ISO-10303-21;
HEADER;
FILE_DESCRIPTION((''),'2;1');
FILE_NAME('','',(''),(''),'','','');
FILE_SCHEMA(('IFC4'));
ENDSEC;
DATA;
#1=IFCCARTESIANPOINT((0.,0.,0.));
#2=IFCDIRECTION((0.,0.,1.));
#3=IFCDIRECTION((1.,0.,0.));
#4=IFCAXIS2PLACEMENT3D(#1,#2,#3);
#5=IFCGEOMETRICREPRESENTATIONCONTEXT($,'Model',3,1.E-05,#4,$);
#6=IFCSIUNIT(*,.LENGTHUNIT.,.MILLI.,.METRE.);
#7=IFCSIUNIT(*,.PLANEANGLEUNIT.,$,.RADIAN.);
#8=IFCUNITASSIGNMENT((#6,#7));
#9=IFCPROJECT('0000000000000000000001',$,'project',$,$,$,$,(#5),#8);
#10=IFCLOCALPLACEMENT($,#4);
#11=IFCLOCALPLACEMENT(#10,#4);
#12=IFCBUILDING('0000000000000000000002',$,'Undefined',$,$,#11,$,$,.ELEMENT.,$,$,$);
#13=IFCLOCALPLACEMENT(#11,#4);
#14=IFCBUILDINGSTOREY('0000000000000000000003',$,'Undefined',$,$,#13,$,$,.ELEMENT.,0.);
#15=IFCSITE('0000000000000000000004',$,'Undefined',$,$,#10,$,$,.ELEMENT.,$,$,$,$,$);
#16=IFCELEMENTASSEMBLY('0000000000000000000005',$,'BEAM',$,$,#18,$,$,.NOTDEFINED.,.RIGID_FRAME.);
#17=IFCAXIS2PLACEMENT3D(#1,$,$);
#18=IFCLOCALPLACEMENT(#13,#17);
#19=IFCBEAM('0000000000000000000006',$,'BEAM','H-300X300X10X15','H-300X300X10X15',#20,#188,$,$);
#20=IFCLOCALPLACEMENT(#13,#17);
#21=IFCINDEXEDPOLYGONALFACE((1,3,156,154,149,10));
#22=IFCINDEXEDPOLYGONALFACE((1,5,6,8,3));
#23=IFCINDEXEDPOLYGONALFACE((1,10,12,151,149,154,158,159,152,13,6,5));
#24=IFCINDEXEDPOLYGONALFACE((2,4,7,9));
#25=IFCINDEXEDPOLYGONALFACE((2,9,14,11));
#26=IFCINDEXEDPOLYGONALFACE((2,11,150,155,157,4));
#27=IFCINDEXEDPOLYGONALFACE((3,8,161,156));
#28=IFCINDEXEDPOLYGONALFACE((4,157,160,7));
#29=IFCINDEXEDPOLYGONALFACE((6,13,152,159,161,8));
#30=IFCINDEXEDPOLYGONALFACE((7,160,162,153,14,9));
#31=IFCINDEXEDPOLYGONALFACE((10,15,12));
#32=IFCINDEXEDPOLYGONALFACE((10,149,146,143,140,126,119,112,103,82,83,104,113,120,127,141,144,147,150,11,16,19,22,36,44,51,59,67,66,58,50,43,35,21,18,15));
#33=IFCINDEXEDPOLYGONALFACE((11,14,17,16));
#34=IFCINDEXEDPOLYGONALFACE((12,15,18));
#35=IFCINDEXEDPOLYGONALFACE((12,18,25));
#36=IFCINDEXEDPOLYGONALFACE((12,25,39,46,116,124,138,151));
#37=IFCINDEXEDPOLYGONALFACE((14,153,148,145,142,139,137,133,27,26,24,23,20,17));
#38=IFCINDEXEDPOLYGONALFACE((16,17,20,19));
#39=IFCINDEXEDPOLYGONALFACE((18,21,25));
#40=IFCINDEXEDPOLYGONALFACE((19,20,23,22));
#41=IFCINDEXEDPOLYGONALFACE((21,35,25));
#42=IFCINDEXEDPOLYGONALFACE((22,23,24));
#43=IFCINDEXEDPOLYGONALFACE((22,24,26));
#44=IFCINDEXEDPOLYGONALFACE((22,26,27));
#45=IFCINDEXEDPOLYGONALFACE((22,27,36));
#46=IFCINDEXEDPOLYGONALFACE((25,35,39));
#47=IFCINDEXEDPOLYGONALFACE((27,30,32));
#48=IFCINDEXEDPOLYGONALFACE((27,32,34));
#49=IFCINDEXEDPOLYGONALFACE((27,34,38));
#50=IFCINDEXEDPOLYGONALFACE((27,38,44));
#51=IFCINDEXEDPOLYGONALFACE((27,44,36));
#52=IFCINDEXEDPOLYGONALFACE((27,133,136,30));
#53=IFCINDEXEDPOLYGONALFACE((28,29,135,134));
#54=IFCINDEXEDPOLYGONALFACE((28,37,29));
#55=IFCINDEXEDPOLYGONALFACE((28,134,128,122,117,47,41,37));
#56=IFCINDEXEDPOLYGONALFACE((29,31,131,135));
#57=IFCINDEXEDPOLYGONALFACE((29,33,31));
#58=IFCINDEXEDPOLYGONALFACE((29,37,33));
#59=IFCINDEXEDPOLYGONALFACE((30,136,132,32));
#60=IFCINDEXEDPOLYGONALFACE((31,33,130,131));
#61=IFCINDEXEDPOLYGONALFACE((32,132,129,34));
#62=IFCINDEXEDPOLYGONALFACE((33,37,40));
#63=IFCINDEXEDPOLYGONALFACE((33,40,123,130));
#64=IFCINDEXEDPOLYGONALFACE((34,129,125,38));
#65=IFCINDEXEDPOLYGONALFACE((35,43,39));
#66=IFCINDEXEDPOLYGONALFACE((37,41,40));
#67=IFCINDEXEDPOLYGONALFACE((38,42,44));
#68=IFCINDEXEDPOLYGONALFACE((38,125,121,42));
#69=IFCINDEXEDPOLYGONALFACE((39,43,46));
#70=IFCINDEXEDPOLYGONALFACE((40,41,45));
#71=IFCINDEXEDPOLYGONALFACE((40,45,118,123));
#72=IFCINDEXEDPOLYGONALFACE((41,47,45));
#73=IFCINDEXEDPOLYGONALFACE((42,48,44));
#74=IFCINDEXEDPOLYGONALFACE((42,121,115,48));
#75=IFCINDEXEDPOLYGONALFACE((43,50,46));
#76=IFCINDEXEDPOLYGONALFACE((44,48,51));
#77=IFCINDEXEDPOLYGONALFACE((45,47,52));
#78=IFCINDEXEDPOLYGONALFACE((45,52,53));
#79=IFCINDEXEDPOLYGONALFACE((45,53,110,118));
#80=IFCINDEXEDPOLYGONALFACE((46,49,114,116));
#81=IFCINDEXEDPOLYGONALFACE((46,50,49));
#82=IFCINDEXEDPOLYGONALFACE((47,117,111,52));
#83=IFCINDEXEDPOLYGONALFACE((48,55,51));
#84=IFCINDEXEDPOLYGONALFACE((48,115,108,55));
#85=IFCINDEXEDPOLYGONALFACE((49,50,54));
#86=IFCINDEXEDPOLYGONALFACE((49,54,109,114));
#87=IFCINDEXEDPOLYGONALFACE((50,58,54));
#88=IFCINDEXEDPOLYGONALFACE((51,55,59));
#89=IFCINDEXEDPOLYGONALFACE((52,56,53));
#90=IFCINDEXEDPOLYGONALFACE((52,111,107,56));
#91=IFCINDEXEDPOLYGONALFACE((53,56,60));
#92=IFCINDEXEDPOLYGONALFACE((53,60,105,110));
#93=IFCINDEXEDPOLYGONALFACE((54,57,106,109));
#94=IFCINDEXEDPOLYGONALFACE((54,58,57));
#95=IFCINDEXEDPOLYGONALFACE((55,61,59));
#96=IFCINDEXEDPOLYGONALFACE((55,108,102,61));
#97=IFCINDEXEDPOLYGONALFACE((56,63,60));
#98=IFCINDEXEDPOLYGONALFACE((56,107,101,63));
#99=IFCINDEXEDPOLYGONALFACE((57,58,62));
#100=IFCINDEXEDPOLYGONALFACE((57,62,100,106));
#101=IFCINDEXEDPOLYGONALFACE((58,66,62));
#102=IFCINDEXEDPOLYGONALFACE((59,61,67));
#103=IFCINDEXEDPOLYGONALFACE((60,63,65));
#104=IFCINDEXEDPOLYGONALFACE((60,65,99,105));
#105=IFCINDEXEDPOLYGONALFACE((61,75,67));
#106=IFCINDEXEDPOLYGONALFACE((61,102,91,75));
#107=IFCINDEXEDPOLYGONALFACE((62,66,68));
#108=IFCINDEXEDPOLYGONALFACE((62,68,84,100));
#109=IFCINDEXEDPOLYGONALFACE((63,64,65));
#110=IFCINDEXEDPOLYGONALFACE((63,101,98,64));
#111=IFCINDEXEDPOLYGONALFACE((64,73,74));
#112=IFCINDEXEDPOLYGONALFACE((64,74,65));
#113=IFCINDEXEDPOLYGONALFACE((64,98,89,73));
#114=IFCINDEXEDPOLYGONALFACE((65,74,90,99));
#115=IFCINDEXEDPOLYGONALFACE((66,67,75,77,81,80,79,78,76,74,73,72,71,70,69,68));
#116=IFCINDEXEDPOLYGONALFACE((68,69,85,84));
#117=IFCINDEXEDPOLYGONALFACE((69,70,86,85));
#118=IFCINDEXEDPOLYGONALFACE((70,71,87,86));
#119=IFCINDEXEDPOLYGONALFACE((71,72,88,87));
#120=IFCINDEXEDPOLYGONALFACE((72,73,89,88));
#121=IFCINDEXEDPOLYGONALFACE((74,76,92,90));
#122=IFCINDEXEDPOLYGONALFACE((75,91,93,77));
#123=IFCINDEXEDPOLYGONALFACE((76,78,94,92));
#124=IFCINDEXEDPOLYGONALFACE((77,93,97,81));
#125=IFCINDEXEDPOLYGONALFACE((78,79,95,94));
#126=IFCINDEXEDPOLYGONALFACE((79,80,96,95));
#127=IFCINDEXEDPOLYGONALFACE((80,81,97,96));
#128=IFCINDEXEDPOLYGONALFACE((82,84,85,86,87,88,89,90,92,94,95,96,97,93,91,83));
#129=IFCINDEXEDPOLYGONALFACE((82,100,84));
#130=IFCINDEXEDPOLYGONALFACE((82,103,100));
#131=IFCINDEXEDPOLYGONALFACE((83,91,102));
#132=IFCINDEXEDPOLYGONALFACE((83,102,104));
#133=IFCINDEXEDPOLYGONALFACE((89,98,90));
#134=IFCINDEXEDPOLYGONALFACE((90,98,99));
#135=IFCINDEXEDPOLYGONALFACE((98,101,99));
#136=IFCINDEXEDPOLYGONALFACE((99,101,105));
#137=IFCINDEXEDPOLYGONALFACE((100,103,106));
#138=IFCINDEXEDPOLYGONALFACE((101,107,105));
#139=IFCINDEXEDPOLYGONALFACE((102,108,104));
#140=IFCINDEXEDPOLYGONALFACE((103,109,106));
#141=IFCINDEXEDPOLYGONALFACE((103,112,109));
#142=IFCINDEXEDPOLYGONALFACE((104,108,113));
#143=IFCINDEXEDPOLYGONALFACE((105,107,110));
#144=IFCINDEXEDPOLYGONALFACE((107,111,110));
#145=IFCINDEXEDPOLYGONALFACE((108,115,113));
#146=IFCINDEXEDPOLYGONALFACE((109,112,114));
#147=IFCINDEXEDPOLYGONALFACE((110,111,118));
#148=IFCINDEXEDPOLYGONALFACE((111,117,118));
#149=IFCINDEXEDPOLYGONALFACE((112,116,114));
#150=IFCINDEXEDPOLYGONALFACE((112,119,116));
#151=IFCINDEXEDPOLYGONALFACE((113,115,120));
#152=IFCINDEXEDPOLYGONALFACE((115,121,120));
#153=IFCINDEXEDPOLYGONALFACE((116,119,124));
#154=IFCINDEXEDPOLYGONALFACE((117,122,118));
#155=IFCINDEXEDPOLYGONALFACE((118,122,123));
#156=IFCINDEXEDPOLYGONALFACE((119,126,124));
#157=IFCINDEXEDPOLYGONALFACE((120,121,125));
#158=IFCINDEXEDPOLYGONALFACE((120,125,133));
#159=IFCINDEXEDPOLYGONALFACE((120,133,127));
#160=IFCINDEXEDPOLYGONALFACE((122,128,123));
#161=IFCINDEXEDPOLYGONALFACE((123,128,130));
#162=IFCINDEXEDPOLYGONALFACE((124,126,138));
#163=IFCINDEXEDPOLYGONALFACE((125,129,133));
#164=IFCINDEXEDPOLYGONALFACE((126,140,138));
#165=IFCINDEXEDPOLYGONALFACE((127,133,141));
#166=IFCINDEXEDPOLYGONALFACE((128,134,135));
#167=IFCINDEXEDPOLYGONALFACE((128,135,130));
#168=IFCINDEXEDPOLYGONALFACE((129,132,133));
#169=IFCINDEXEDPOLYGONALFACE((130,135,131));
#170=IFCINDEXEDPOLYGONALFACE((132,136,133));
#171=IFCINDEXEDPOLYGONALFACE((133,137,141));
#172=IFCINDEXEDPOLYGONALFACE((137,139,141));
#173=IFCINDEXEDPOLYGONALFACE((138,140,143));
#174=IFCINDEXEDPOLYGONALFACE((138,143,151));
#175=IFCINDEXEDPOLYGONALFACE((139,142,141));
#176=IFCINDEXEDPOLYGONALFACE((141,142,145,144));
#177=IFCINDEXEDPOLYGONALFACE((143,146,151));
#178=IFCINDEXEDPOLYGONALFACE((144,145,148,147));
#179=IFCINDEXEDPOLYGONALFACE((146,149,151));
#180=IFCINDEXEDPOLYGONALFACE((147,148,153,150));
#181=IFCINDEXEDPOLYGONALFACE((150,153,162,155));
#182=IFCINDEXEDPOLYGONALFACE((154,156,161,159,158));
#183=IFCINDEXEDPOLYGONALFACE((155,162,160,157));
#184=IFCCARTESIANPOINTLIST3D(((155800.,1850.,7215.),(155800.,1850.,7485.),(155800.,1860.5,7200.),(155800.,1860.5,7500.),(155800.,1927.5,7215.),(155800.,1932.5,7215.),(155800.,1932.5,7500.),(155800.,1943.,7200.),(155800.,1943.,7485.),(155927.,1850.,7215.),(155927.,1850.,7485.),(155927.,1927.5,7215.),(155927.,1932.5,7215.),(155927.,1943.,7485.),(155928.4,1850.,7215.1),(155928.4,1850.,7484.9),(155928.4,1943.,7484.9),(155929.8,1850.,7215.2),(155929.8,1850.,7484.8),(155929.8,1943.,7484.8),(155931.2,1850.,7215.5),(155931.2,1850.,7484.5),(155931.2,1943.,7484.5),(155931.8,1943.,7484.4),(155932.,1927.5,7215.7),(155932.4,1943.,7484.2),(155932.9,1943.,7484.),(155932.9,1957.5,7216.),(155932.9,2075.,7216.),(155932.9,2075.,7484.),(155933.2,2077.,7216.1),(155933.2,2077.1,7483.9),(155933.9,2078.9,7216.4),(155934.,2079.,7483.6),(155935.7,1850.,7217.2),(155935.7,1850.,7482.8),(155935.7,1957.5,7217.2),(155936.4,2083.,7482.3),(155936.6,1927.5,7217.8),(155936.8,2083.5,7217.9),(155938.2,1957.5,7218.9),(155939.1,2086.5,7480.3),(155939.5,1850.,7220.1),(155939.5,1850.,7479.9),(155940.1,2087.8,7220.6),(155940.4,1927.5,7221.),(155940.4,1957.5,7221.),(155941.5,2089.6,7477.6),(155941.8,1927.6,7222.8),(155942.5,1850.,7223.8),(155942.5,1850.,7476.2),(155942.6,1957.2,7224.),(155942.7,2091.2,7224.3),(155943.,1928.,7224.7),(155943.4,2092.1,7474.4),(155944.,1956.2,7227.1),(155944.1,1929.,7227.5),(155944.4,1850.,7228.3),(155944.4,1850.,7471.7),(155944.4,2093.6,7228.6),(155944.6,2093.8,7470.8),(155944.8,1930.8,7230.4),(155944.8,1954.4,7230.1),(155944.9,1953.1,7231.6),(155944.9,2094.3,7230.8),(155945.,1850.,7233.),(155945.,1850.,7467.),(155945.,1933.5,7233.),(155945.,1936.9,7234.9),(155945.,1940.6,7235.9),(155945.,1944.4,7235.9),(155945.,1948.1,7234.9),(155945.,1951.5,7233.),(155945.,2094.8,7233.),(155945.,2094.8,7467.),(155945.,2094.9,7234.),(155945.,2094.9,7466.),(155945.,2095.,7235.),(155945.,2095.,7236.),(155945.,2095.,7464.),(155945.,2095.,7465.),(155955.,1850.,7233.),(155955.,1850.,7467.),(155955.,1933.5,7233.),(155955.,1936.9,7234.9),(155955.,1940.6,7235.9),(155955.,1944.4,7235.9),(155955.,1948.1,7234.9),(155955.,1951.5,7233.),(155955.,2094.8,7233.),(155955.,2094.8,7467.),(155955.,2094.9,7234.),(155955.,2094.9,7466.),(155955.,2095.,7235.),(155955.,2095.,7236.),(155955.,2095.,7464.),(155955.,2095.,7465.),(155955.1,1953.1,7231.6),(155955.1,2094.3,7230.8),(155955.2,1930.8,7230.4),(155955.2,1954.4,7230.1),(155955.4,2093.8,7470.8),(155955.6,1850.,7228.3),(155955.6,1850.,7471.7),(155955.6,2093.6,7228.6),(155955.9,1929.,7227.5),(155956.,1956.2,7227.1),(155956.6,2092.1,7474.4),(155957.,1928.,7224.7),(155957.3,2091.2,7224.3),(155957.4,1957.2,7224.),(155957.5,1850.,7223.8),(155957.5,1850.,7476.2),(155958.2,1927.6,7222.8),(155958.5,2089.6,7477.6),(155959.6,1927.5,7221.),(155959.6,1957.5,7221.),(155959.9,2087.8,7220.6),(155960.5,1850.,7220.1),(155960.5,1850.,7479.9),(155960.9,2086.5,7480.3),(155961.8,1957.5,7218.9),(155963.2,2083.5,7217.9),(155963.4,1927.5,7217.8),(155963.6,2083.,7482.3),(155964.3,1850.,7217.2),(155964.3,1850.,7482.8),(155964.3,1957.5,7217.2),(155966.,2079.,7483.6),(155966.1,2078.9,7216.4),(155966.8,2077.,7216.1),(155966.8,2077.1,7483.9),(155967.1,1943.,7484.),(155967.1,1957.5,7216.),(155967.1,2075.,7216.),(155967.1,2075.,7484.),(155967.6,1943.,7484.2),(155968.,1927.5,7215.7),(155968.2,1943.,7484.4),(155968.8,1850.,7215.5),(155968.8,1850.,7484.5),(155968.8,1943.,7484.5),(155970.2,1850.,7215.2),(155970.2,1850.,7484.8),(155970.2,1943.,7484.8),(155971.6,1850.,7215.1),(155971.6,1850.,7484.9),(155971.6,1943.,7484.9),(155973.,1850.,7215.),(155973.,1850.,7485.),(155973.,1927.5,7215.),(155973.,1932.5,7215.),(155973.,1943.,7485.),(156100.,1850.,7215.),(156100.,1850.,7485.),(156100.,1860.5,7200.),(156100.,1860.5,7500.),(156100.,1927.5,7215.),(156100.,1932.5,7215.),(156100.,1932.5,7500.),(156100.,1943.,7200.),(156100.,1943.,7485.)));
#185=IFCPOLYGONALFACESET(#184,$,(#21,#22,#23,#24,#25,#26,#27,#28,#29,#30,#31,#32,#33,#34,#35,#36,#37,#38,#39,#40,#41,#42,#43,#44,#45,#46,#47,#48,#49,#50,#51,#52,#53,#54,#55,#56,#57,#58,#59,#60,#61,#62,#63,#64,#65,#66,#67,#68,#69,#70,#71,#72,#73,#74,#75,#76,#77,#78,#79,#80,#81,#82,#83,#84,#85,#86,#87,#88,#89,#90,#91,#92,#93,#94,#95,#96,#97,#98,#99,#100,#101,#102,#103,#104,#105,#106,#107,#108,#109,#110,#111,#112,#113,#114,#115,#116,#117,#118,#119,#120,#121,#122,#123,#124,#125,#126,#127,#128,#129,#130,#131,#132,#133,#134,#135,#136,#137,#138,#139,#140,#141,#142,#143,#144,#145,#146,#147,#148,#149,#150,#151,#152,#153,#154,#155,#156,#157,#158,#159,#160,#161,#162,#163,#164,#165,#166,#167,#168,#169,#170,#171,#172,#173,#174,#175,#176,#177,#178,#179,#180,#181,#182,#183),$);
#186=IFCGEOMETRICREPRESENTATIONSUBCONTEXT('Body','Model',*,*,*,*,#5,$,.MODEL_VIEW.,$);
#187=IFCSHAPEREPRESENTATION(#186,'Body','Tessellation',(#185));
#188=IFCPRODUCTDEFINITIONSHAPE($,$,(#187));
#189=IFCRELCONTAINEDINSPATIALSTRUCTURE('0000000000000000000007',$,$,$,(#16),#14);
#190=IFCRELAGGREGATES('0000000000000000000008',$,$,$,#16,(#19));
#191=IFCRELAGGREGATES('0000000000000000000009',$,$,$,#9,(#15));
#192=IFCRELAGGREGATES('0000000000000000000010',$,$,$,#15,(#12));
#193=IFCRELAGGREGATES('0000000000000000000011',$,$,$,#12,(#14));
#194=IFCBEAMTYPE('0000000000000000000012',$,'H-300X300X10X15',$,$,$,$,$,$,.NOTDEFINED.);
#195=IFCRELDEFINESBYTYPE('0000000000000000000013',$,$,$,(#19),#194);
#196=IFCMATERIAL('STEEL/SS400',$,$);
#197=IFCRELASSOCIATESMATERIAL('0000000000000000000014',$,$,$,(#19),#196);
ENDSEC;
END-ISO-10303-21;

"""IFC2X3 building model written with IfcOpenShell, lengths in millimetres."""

from ifc_helpers import new_model, si_unit, frame, frame_2d, origin_with_axes, origin_2d_with_axis, place, context, subcontext, project, spatial, polyline, circle_curve, parameter, trimmed, segment, composite_curve, i_section, outline, extrude, boolean, material, type_object, element, aggregate, save


model = new_model("IFC2X3")

# Units and contexts
model_context = context("Model", 3, precision=1e-05, world=origin_with_axes())
body_context = subcontext(model_context, "Body", "Model", "MODEL_VIEW")
ifc_project = project(units=[si_unit("LENGTHUNIT", "METRE", prefix="MILLI"), si_unit("PLANEANGLEUNIT", "RADIAN")], contexts=[model_context])

# Site, building, storey
site_placement = place(None, origin_with_axes())
site = spatial("IfcSite", under=ifc_project, at=site_placement, Name="Undefined", CompositionType="ELEMENT")
building_placement = place(site_placement, origin_with_axes())
building = spatial("IfcBuilding", under=site, at=building_placement, Name="Undefined", CompositionType="ELEMENT")
storey_placement = place(building_placement, origin_with_axes())
storey = spatial("IfcBuildingStorey", under=building, at=storey_placement, Name="Undefined", CompositionType="ELEMENT", Elevation=0.0)

# Shared definitions
ifc_material_1 = material(Name="STEEL/SS400")

# Element assembly, beam
assembly_1_placement = place(storey_placement, origin_with_axes())
assembly_1 = element("IfcElementAssembly", 1, at=assembly_1_placement, inside=storey, Name="BEAM", AssemblyPlace="NOTDEFINED", PredefinedType="RIGID_FRAME")
beam_type_1 = type_object("IfcBeamType", Name="H-300X300X10X15", PredefinedType="NOTDEFINED")
beam_1_placement = place(assembly_1_placement, frame((155950.0, 2100.0, 7350.0), z_axis=(0.0, 0.0, 1.0), x_axis=(0.0, -1.0, 0.0)))
beam_1 = element("IfcBeam", 2, at=beam_1_placement, type_object=beam_type_1, material=ifc_material_1, Name="BEAM", Description="H-300X300X10X15", ObjectType="H-300X300X10X15", context=body_context, shape_type="CSG", body=[
    boolean("DIFFERENCE", boolean("DIFFERENCE", boolean("DIFFERENCE", boolean("DIFFERENCE", boolean("DIFFERENCE", boolean("DIFFERENCE", extrude(i_section(OverallWidth=300.0, OverallDepth=300.0, WebThickness=10.0, FlangeThickness=15.0, FilletRadius=18.0, at=origin_2d_with_axis()), frame((250.0, 0.0, 0.0), z_axis=(-1.0, 0.0, 0.0), x_axis=(0.0, -1.0, 0.0)), (0.0, 0.0, 1.0), 250.0), extrude(outline(composite_curve([segment(polyline([(0.0, 0.0), (7.5, 0.0), (7.5, 5.0)]), True, "CONTINUOUS"), segment(trimmed(circle_curve(frame_2d((-7.5, 5.0), x_axis=(1.0, 0.0)), 15.0), [parameter(0.0)], [parameter(1.570796)], True, "PARAMETER"), True, "CONTINUOUS"), segment(polyline([(-7.5, 20.0), (-7.5, 20.0)]), True, "CONTINUOUS"), segment(trimmed(circle_curve(frame_2d((-7.5, 5.0), x_axis=(0.0, 1.0)), 15.0), [parameter(0.0)], [parameter(1.570796)], True, "PARAMETER"), True, "CONTINUOUS"), segment(polyline([(-22.5, 5.0), (-22.5, -1.0), (-7.0, -1.0), (-7.0, 0.0), (0.0, 0.0)]), True, "CONTINUOUS")], self_intersect=True)), frame((150.0, -152.5, -134.0), z_axis=(0.0, 1.0, 0.0), x_axis=(-1.0, 0.0, 0.0)), (0.0, 0.0, 1.0), 305.0)), extrude(outline(polyline([(0.0, 0.0), (15.5, 0.0), (5.0, 15.0), (5.0, 15.5), (0.0, 15.5), (0.0, 0.0)])), frame((255.0, 155.0, 150.0), z_axis=(0.0, -1.0, 0.0), x_axis=(-1.0, 0.0, 0.0)), (0.0, 0.0, 1.0), 310.0)), extrude(outline(polyline([(0.0, 0.0), (15.5, 0.0), (5.0, 15.0), (5.0, 15.5), (0.0, 15.5), (0.0, 0.0)])), frame((255.0, -155.0, -150.0), z_axis=(0.0, 1.0, 0.0), x_axis=(-1.0, 0.0, 0.0)), (0.0, 0.0, 1.0), 310.0)), extrude(outline(polyline([(0.0, 0.0), (167.5, 0.0), (157.0, 15.0), (157.0, 15.5), (0.0, 15.5), (0.0, 0.0)])), frame((0.0, -155.0, 150.0), z_axis=(0.0, 1.0, 0.0), x_axis=(1.0, 0.0, 0.0)), (0.0, 0.0, 1.0), 310.0)), extrude(outline(polyline([(0.0, 0.0), (167.5, 0.0), (157.0, 15.0), (157.0, 15.5), (0.0, 15.5), (0.0, 0.0)])), frame((0.0, -155.0, -135.0), z_axis=(0.0, 1.0, 0.0), x_axis=(1.0, 0.0, 0.0)), (0.0, 0.0, 1.0), 310.0)), extrude(outline(composite_curve([segment(polyline([(0.0, 0.0), (16.0, 0.0), (16.0, 132.0)]), True, "CONTINUOUS"), segment(trimmed(circle_curve(frame_2d((36.0, 132.0), x_axis=(-1.0, 0.0)), 20.0), [parameter(0.0)], [parameter(4.712389)], False, "PARAMETER"), True, "CONTINUOUS"), segment(polyline([(36.0, 152.0), (264.0, 152.0)]), True, "CONTINUOUS"), segment(trimmed(circle_curve(frame_2d((264.0, 132.0), x_axis=(0.0, 1.0)), 20.0), [parameter(0.0)], [parameter(4.712389)], False, "PARAMETER"), True, "CONTINUOUS"), segment(polyline([(284.0, 132.0), (284.0, 0.0), (300.0, 0.0), (300.0, 307.0), (0.0, 307.0), (0.0, 0.0)]), True, "CONTINUOUS")], self_intersect=True)), frame((157.0, -152.5, 150.0), z_axis=(0.0, 1.0, 0.0), x_axis=(0.0, 0.0, -1.0)), (0.0, 0.0, 1.0), 305.0)),
])

aggregate(assembly_1, [beam_1])

save(model, "model.ifc")
